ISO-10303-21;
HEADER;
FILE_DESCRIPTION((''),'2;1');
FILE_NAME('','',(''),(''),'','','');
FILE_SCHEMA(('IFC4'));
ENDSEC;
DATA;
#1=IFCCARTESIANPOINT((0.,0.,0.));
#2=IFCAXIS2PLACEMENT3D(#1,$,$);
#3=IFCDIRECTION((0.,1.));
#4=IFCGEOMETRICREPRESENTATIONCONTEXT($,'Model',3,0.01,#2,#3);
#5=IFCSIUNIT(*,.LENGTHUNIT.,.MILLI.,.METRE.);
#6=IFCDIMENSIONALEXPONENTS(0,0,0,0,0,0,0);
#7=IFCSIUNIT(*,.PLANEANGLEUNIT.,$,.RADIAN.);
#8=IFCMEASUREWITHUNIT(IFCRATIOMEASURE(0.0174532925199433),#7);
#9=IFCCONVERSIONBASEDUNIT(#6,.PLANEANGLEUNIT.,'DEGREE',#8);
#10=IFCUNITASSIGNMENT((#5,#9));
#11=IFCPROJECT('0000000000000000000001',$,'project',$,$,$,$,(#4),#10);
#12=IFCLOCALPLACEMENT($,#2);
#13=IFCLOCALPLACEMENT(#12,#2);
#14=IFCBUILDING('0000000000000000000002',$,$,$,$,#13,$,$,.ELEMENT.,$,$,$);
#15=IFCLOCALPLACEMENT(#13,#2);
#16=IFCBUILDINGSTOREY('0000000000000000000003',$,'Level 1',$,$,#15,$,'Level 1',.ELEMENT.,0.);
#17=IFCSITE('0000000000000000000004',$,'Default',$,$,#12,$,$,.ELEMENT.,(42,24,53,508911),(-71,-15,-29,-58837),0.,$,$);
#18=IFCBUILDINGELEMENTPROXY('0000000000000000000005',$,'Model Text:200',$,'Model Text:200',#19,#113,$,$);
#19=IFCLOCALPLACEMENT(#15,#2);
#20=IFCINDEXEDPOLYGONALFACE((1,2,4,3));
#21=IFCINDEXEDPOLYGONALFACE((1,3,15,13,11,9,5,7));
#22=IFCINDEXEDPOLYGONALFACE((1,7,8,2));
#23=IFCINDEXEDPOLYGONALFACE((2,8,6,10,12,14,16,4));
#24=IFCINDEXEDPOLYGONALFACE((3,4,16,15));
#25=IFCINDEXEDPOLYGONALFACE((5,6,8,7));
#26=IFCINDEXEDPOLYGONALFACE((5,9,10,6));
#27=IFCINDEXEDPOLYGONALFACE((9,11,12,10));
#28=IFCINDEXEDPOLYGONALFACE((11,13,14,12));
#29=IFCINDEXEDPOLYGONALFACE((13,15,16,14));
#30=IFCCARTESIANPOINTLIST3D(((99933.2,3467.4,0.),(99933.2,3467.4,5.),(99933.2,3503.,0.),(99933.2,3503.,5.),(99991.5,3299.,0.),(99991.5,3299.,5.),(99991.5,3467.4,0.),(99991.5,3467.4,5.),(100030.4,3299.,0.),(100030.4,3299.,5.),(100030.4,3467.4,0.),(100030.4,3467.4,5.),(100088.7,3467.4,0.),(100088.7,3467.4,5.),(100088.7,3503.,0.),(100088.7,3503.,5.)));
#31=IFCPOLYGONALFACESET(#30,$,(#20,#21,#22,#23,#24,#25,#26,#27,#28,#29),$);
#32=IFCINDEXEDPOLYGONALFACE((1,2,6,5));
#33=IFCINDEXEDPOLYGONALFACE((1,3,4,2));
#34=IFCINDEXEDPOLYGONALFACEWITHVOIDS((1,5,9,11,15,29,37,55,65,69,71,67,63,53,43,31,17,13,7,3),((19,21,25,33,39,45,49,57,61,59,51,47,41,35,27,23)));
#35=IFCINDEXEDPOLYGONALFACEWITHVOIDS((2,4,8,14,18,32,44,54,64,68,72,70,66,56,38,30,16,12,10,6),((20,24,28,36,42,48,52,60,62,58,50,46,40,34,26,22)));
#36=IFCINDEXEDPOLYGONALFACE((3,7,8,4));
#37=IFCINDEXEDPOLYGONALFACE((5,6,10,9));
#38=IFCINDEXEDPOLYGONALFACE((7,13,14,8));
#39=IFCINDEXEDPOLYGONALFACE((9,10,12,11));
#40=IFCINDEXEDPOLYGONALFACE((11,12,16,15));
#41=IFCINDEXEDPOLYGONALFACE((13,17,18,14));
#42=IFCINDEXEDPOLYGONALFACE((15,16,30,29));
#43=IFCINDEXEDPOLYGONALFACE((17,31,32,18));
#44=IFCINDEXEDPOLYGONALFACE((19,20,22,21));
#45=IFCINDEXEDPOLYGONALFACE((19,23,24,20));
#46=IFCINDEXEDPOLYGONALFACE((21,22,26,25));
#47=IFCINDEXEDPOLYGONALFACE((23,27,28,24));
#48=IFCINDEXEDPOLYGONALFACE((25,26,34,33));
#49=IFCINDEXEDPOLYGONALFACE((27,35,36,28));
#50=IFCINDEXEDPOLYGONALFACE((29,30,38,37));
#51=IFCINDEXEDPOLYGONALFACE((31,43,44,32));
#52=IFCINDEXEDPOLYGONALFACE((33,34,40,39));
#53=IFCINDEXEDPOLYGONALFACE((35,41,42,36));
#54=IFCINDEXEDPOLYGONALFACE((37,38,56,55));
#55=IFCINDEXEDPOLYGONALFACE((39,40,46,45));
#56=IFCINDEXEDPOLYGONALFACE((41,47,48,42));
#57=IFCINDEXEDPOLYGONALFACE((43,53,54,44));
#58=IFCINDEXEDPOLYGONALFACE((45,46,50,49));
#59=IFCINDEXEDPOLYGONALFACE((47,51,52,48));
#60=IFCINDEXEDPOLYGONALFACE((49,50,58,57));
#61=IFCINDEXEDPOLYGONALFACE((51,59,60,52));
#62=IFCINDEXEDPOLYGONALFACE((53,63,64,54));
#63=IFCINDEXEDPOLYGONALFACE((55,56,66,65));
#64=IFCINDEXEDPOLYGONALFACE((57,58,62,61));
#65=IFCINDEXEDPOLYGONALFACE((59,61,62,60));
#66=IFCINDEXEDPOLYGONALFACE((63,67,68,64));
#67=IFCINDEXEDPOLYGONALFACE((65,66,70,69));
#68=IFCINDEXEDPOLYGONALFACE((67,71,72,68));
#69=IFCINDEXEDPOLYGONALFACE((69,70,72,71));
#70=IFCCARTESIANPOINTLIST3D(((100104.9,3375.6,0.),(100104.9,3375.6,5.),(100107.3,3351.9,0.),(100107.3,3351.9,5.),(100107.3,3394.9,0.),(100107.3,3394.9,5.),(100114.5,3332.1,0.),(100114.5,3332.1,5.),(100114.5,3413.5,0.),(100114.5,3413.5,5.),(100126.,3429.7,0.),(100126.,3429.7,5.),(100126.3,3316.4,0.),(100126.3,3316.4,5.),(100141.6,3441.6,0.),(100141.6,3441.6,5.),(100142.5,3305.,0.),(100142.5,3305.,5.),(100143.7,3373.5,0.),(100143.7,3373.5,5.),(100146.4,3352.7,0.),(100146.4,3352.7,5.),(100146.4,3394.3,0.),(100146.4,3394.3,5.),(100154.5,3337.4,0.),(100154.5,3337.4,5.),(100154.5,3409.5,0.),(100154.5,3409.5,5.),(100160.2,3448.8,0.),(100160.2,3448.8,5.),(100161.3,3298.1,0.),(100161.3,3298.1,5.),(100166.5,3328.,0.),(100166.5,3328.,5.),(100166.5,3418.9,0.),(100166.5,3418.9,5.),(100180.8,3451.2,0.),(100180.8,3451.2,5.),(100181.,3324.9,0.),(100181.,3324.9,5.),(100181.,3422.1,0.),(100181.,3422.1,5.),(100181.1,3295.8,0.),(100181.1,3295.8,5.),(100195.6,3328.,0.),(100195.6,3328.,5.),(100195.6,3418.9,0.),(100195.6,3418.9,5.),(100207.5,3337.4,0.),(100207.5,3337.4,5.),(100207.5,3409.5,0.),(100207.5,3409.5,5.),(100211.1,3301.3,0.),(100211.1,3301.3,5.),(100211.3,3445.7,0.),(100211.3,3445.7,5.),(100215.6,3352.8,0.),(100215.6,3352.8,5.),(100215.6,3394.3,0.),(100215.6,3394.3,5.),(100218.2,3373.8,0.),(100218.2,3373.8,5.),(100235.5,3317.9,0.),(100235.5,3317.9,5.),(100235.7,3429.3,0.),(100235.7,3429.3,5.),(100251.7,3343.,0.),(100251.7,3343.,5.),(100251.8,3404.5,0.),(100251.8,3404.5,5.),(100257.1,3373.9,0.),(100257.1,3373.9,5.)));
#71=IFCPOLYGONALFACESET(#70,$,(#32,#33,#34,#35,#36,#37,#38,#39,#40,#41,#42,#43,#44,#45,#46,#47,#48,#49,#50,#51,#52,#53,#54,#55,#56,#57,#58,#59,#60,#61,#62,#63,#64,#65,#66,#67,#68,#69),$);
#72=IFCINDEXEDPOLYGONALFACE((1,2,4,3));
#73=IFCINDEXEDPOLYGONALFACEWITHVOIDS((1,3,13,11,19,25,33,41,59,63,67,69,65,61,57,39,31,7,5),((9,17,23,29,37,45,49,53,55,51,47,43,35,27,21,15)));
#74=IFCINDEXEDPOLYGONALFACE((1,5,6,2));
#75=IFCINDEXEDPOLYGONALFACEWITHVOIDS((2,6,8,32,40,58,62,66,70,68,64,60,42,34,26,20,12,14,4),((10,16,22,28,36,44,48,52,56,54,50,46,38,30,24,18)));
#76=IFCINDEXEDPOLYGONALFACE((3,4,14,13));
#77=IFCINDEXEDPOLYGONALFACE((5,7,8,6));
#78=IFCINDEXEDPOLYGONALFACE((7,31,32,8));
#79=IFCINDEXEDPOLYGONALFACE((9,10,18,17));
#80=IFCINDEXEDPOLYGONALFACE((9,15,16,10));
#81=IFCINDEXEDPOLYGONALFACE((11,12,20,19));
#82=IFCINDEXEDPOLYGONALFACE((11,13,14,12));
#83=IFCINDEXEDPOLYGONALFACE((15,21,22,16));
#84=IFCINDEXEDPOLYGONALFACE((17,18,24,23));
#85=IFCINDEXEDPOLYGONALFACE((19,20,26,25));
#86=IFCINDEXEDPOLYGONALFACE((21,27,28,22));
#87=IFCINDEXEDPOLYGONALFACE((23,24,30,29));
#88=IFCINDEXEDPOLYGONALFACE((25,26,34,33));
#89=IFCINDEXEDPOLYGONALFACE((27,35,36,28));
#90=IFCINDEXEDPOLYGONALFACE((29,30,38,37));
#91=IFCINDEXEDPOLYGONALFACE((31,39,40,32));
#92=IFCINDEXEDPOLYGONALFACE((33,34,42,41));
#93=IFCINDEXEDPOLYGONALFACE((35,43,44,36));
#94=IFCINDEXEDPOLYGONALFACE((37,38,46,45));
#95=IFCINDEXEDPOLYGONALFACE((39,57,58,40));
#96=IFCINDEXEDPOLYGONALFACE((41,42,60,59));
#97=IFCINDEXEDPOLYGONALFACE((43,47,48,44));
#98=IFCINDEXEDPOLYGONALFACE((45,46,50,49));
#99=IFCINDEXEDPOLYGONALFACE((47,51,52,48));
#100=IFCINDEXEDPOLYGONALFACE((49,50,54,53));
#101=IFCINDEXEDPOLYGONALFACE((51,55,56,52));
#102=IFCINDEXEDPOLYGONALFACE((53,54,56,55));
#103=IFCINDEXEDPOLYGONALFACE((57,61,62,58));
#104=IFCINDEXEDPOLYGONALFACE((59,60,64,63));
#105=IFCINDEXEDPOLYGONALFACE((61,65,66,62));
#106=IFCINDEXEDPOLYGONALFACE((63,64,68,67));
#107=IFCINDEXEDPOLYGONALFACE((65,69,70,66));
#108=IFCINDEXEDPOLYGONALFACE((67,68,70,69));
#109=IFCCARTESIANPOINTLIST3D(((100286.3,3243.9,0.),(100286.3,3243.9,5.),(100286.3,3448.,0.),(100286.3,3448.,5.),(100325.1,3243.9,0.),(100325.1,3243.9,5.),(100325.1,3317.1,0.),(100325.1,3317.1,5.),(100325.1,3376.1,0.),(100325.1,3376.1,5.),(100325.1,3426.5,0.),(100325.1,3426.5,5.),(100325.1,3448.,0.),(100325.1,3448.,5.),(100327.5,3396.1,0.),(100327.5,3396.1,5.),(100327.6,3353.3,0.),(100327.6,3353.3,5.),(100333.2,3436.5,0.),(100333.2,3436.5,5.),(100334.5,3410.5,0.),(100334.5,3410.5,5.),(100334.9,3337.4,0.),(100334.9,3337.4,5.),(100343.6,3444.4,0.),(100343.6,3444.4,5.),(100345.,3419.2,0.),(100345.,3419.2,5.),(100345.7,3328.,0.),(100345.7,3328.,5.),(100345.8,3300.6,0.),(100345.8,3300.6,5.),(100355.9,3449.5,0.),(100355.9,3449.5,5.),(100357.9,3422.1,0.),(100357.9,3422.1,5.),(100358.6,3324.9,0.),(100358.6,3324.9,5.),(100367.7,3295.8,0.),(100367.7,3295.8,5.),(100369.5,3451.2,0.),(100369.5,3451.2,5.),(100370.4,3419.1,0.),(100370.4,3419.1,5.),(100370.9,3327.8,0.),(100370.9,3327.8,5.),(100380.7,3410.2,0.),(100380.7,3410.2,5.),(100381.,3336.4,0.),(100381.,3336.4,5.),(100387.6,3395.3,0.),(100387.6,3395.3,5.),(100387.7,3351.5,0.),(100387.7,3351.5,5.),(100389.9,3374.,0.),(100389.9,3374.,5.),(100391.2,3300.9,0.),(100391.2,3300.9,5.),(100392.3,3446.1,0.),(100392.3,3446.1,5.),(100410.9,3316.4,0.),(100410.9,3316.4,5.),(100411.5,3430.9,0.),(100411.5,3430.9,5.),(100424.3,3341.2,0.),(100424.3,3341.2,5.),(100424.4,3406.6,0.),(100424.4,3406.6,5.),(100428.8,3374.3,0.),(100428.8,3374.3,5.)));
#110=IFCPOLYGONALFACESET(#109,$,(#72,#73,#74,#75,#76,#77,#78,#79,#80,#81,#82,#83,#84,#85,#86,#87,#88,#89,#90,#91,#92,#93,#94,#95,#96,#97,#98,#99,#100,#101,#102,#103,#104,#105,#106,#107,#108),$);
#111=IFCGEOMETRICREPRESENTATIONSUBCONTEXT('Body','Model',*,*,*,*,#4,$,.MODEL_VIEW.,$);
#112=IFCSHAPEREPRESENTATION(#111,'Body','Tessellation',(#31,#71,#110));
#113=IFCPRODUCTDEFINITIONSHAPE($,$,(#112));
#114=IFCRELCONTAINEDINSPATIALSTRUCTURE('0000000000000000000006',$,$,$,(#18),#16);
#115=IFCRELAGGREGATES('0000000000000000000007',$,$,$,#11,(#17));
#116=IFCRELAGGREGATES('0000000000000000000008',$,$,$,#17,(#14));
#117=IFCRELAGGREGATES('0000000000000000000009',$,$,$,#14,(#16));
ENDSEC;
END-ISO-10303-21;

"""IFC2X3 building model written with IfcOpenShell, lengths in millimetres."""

from ifc_helpers import new_model, entity, si_unit, converted_unit, direction, frame, origin, place, context, subcontext, project, spatial, polyline, outline, extrude, element, save


model = new_model("IFC2X3")

# Units and contexts
model_context = context("Model", 3, precision=0.01, world=origin(), true_north=direction((0.0, 1.0)))
body_context = subcontext(model_context, "Body", "Model", "MODEL_VIEW")
ifc_project = project(units=[si_unit("LENGTHUNIT", "METRE", prefix="MILLI"), converted_unit("PLANEANGLEUNIT", "DEGREE", entity("IfcRatioMeasure", 0.0174532925199433), si_unit("PLANEANGLEUNIT", "RADIAN"), dimensions=[0, 0, 0, 0, 0, 0, 0])], contexts=[model_context])

# Site, building, storey
site_placement = place(None, origin())
site = spatial("IfcSite", under=ifc_project, at=site_placement, Name="Default", CompositionType="ELEMENT", RefLatitude=(42, 24, 53, 508911), RefLongitude=(-71, -15, -29, -58837), RefElevation=0.0)
building_placement = place(site_placement, origin())
building = spatial("IfcBuilding", under=site, at=building_placement, CompositionType="ELEMENT")
storey_placement = place(building_placement, origin())
storey = spatial("IfcBuildingStorey", under=building, at=storey_placement, Name="Level 1", LongName="Level 1", CompositionType="ELEMENT", Elevation=0.0)

# Building element proxy
proxy_1_placement = place(storey_placement, origin())
element("IfcBuildingElementProxy", 1, at=proxy_1_placement, inside=storey, Name="Model Text:200", ObjectType="Model Text:200", context=body_context, shape_type="SweptSolid", body=[
    extrude(outline(polyline([(-19.4, -135.2), (19.4, -135.2), (19.4, 33.2), (77.7, 33.2), (77.7, 68.8), (-77.7, 68.8), (-77.7, 33.2), (-19.4, 33.2), (-19.4, -135.2)])), frame((100010.9, 3434.2, 0.0)), (0.0, 0.0, 1.0), 5.0),
    extrude(outline(polyline([(-8.8, -65.7), (15.1, -65.7), (35.5, -60.5), (52.3, -50.4), (65.3, -35.4), (74.1, -17.3), (78.4, 2.1), (75.9, 32.5), (61.8, 58.5), (38.4, 77.1), (8.3, 85.6), (-22.7, 83.3), (-49.0, 69.9), (-67.8, 47.3), (-76.3, 17.5), (-76.0, -3.3), (-70.7, -22.5), (-60.5, -39.2), (-45.5, -52.3), (-27.7, -61.4), (-8.8, -65.7)]), holes=[polyline([(-2.7, -27.2), (-23.1, -22.5), (-37.5, -12.9), (-45.7, 0.0), (-47.3, 14.8), (-42.7, 28.9), (-32.2, 39.9), (-16.3, 46.3), (4.5, 46.9), (25.1, 42.1), (39.6, 32.6), (47.7, 19.7), (49.4, 5.0), (44.8, -9.2), (34.2, -20.2), (18.2, -26.7), (-2.7, -27.2)])]), frame((100171.1, 3373.5, 0.0), z_axis=(0.0, 0.0, 1.0), x_axis=(0.100608, -0.994926, 0.0)), (0.0, 0.0, 1.0), 5.0),
    extrude(outline(polyline([(-73.1, -75.4), (130.9, -75.4), (130.9, -36.6), (57.8, -36.6), (74.3, -15.9), (79.1, 6.0), (73.9, 29.5), (58.4, 49.2), (33.6, 62.6), (0.5, 67.1), (-31.8, 62.8), (-56.1, 49.8), (-71.3, 30.7), (-76.4, 7.8), (-74.7, -5.8), (-69.6, -18.1), (-61.7, -28.5), (-51.7, -36.6), (-73.1, -36.6), (-73.1, -75.4)]), holes=[polyline([(-1.2, -36.6), (-21.2, -34.2), (-35.6, -27.2), (-44.3, -16.7), (-47.2, -3.8), (-44.3, 8.7), (-35.4, 19.0), (-20.4, 25.9), (0.8, 28.2), (23.3, 26.0), (38.5, 19.3), (47.1, 9.2), (49.9, -3.1), (46.8, -16.0), (37.4, -26.8), (21.5, -34.1), (-1.2, -36.6)])]), frame((100361.7, 3374.8, 0.0), z_axis=(0.0, 0.0, 1.0), x_axis=(0.0, -1.0, 0.0)), (0.0, 0.0, 1.0), 5.0),
])

save(model, "model.ifc")
